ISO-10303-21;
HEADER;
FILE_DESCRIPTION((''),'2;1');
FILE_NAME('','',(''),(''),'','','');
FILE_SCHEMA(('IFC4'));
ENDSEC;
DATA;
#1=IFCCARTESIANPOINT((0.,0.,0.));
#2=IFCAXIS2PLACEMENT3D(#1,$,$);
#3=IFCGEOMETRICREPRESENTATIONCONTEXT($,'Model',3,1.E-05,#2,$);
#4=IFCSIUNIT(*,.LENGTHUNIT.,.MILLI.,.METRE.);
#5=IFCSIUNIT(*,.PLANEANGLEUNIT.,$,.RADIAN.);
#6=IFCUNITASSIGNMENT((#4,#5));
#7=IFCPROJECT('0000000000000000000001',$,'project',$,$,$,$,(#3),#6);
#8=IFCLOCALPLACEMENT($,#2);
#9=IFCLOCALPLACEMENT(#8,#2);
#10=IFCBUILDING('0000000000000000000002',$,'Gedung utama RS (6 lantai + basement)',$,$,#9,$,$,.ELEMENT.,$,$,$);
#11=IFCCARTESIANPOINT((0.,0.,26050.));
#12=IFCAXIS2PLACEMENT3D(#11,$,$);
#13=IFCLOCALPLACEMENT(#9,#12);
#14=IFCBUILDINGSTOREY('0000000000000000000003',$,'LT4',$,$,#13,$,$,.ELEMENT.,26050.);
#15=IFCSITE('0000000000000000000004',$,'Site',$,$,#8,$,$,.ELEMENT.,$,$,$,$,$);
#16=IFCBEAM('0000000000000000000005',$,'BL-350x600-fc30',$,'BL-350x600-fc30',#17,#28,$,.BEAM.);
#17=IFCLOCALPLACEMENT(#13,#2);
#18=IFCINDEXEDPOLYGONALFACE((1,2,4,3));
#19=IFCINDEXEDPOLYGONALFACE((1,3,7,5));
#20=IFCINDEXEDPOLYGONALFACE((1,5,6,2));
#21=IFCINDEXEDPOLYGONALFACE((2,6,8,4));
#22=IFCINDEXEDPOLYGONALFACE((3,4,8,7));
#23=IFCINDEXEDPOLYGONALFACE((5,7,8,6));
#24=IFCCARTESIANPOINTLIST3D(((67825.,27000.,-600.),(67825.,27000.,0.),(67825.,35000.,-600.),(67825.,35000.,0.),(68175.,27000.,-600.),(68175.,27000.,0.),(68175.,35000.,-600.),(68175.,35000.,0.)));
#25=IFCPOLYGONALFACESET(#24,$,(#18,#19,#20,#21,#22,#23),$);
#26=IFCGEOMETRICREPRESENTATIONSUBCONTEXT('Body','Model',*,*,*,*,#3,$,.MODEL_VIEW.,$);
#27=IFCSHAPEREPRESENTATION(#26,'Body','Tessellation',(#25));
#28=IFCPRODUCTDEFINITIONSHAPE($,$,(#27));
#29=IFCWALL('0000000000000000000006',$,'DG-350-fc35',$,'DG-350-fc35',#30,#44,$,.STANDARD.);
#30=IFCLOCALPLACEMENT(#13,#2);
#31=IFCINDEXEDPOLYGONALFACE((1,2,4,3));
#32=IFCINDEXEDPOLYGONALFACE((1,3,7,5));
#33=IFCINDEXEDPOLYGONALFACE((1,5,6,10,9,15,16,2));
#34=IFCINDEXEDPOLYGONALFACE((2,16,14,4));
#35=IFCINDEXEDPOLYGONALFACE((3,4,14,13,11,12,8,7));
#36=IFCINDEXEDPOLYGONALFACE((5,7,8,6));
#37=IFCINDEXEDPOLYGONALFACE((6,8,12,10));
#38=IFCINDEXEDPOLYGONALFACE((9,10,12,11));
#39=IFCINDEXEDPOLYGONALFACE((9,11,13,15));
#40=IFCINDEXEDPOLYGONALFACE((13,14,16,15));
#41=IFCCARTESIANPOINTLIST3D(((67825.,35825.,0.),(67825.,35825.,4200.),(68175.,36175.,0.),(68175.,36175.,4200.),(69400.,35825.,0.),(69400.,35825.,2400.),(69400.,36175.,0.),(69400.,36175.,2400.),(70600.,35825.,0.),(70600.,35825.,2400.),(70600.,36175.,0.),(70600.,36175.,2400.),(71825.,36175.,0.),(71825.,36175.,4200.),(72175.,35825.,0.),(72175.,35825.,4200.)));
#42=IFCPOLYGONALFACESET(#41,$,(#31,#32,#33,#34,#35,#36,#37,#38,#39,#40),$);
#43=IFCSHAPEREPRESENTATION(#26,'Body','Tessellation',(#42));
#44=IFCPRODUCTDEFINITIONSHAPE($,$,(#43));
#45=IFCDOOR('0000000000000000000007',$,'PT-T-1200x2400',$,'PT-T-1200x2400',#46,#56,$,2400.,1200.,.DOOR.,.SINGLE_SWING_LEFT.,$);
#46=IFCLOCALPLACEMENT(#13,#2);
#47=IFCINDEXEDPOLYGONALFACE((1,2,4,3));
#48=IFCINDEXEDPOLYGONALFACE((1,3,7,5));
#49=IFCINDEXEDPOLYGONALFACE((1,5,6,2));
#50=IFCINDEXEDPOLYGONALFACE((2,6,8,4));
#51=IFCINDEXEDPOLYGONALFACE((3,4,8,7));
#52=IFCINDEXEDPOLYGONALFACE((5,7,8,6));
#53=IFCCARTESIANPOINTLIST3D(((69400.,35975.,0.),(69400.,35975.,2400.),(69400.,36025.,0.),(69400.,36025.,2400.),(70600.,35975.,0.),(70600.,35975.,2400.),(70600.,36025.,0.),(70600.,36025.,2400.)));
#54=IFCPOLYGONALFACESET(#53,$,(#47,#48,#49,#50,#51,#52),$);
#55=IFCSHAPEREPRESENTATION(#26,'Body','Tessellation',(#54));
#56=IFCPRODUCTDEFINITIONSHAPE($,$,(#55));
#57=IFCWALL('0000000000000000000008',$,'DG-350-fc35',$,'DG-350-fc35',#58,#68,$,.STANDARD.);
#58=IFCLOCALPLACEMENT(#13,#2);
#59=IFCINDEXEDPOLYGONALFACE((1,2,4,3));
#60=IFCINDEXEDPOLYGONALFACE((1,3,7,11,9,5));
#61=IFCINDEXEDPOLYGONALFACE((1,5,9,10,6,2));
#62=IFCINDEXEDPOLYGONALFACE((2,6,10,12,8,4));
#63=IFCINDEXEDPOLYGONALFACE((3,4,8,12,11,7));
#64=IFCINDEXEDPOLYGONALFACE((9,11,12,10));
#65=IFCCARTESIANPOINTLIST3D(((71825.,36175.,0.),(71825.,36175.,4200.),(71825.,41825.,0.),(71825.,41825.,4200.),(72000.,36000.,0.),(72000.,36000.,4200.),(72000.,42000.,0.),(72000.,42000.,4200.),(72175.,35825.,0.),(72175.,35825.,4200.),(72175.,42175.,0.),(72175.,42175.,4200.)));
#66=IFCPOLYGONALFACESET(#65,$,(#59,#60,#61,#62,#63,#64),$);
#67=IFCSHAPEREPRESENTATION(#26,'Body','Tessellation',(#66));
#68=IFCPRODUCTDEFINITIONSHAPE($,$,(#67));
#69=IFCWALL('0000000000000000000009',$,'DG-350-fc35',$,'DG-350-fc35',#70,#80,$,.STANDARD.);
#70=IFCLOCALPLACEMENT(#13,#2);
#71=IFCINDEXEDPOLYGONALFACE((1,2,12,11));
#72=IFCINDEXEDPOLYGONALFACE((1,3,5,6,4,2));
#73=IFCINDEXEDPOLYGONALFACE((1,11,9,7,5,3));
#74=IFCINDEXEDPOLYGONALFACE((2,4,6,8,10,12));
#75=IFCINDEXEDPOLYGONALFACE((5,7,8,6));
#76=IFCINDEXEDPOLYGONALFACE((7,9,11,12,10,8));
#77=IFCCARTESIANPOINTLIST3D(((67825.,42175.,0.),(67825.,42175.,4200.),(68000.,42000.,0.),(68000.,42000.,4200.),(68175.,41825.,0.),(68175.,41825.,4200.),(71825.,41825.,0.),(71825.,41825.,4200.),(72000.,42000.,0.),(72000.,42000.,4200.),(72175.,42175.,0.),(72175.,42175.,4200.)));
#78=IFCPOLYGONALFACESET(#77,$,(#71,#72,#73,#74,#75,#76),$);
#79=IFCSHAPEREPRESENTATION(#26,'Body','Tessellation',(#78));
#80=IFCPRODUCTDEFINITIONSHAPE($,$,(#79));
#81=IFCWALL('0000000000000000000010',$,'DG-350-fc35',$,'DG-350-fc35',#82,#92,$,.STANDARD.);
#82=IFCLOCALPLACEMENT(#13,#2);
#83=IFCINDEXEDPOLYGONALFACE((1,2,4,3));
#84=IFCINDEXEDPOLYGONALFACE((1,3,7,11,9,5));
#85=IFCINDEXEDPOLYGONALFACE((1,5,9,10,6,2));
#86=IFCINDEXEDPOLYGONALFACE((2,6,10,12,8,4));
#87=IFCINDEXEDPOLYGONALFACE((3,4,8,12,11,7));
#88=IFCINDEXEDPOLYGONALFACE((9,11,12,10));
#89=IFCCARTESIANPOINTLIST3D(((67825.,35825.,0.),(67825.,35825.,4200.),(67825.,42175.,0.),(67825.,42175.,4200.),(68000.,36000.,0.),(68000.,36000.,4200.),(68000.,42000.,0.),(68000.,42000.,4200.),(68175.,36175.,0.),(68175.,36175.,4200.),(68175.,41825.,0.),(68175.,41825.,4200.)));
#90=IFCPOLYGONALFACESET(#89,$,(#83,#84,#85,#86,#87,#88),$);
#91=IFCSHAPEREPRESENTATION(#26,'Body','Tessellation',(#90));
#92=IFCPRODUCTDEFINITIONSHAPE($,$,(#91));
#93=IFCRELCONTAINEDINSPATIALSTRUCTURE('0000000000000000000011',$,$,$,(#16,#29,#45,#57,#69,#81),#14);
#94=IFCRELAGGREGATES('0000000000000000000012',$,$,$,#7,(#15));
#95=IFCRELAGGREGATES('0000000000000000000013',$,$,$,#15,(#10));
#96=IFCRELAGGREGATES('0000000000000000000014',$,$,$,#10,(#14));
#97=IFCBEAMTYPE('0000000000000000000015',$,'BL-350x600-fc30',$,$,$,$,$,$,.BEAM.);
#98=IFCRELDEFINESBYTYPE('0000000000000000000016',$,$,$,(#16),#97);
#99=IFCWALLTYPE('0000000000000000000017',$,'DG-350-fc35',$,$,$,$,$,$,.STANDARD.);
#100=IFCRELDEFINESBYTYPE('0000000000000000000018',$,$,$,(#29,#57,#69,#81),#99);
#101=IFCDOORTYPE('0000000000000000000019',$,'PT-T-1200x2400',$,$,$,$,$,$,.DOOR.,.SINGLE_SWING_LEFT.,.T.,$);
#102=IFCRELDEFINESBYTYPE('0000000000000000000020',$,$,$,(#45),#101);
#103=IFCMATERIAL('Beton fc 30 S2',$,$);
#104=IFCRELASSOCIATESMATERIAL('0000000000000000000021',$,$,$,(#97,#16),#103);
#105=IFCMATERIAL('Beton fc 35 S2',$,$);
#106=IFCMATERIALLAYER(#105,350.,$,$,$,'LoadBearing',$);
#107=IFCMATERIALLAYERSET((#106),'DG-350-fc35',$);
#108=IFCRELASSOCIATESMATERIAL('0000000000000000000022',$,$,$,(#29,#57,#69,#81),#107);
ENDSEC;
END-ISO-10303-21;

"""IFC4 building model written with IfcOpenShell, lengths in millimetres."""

from ifc_helpers import new_model, si_unit, frame, frame_2d, origin, origin_2d, place, context, subcontext, project, spatial, polyline, rectangle, outline, extrude, material, layer, layer_set, layer_usage, material_profile, profile_set, profile_usage, type_object, element, fill, save


model = new_model("IFC4")

# Units and contexts
model_context = context("Model", 3, precision=1e-05, world=origin())
body_context = subcontext(model_context, "Body", "Model", "MODEL_VIEW")
ifc_project = project(units=[si_unit("LENGTHUNIT", "METRE", prefix="MILLI"), si_unit("PLANEANGLEUNIT", "RADIAN")], contexts=[model_context])

# Site, building, storey
site_placement = place(None, origin())
site = spatial("IfcSite", under=ifc_project, at=site_placement, Name="Site", CompositionType="ELEMENT")
building_placement = place(site_placement, origin())
building = spatial("IfcBuilding", under=site, at=building_placement, Name="Gedung utama RS (6 lantai + basement)", CompositionType="ELEMENT")
storey_placement = place(building_placement, frame((0.0, 0.0, 26050.0)))
storey = spatial("IfcBuildingStorey", under=building, at=storey_placement, Name="LT4", CompositionType="ELEMENT", Elevation=26050.0)

# Beam
ifc_material_1 = material(Name="Beton fc 30 S2")
ifc_material_profile_1 = material_profile(ifc_material_1, rectangle(XDim=350.0, YDim=600.0, at=origin_2d()), Name="BL-350x600-fc30")
ifc_profile_set_1 = profile_set([ifc_material_profile_1], Name="BL-350x600-fc30")
ifc_profile_usage_1 = profile_usage(ifc_profile_set_1, cardinal=8)
beam_type = type_object("IfcBeamType", Name="BL-350x600-fc30", PredefinedType="BEAM", material=ifc_profile_set_1)
beam_1_placement = place(storey_placement, frame((68000.0, 27000.0, -300.0)))
element("IfcBeam", 1, at=beam_1_placement, inside=storey, type_object=beam_type, material=ifc_profile_usage_1, Name="BL-350x600-fc30", ObjectType="BL-350x600-fc30", PredefinedType="BEAM", context=body_context, shape_type="SweptSolid", body=[
    extrude(rectangle(XDim=350.0, YDim=600.0, at=origin_2d()), frame((0.0, 0.0, 0.0), z_axis=(0.0, 1.0, 0.0), x_axis=(-1.0, 0.0, 0.0)), (0.0, 0.0, 1.0), 8000.0),
])

# Wall, opening, door
ifc_material_2 = material(Name="Beton fc 35 S2")
ifc_layer = layer(ifc_material_2, 350.0, Category="LoadBearing")
ifc_layer_set = layer_set([ifc_layer], Name="DG-350-fc35")
ifc_layer_usage = layer_usage(ifc_layer_set, "AXIS2", "NEGATIVE", 175.0)
wall_type = type_object("IfcWallType", Name="DG-350-fc35", PredefinedType="STANDARD")
wall_1_placement = place(storey_placement, frame((68000.0, 36000.0, 0.0), z_axis=(0.0, 0.0, 1.0), x_axis=(1.0, 0.0, 0.0)))
wall_1 = element("IfcWall", 2, at=wall_1_placement, inside=storey, type_object=wall_type, material=ifc_layer_usage, Name="DG-350-fc35", ObjectType="DG-350-fc35", PredefinedType="STANDARD", context=body_context, shape_type="SweptSolid", body=[
    extrude(outline(polyline([(-175.0, -175.0), (0.0, 0.0), (175.0, 175.0), (3825.0, 175.0), (4000.0, 0.0), (4175.0, -175.0), (-175.0, -175.0)])), origin(), (0.0, 0.0, 1.0), 4200.0),
])
opening_placement = place(wall_1_placement, frame((1400.0, 0.0, 0.0), z_axis=(0.0, 0.0, 1.0), x_axis=(1.0, 0.0, 0.0)))
opening = element("IfcOpeningElement", 3, at=opening_placement, cuts=wall_1, PredefinedType="OPENING", context=body_context, shape_type="SweptSolid", body=[
    extrude(rectangle(XDim=1200.0, YDim=370.0, at=frame_2d((600.0, 0.0))), origin(), (0.0, 0.0, 1.0), 2400.0),
])
door_type = type_object("IfcDoorType", Name="PT-T-1200x2400", OperationType="SINGLE_SWING_LEFT", ParameterTakesPrecedence=True, PredefinedType="DOOR")
door_placement = place(opening_placement, origin())
door = element("IfcDoor", 4, at=door_placement, inside=storey, type_object=door_type, Name="PT-T-1200x2400", ObjectType="PT-T-1200x2400", OperationType="SINGLE_SWING_LEFT", OverallHeight=2400.0, OverallWidth=1200.0, PredefinedType="DOOR", context=body_context, shape_type="SweptSolid", body=[
    extrude(rectangle(XDim=1200.0, YDim=50.0, at=frame_2d((600.0, 0.0))), origin(), (0.0, 0.0, 1.0), 2400.0),
])
fill(opening, door)

# Walls
wall_2_placement = place(storey_placement, frame((72000.0, 36000.0, 0.0), z_axis=(0.0, 0.0, 1.0), x_axis=(0.0, 1.0, 0.0)))
element("IfcWall", 5, at=wall_2_placement, inside=storey, type_object=wall_type, material=ifc_layer_usage, Name="DG-350-fc35", ObjectType="DG-350-fc35", PredefinedType="STANDARD", context=body_context, shape_type="SweptSolid", body=[
    extrude(outline(polyline([(-175.0, -175.0), (0.0, 0.0), (175.0, 175.0), (5825.0, 175.0), (6000.0, 0.0), (6175.0, -175.0), (-175.0, -175.0)])), origin(), (0.0, 0.0, 1.0), 4200.0),
])
wall_3_placement = place(storey_placement, frame((72000.0, 42000.0, 0.0), z_axis=(0.0, 0.0, 1.0), x_axis=(-1.0, 0.0, 0.0)))
element("IfcWall", 6, at=wall_3_placement, inside=storey, type_object=wall_type, material=ifc_layer_usage, Name="DG-350-fc35", ObjectType="DG-350-fc35", PredefinedType="STANDARD", context=body_context, shape_type="SweptSolid", body=[
    extrude(outline(polyline([(-175.0, -175.0), (0.0, 0.0), (175.0, 175.0), (3825.0, 175.0), (4000.0, 0.0), (4175.0, -175.0), (-175.0, -175.0)])), origin(), (0.0, 0.0, 1.0), 4200.0),
])
wall_4_placement = place(storey_placement, frame((68000.0, 42000.0, 0.0), z_axis=(0.0, 0.0, 1.0), x_axis=(0.0, -1.0, 0.0)))
element("IfcWall", 7, at=wall_4_placement, inside=storey, type_object=wall_type, material=ifc_layer_usage, Name="DG-350-fc35", ObjectType="DG-350-fc35", PredefinedType="STANDARD", context=body_context, shape_type="SweptSolid", body=[
    extrude(outline(polyline([(-175.0, -175.0), (0.0, 0.0), (175.0, 175.0), (5825.0, 175.0), (6000.0, 0.0), (6175.0, -175.0), (-175.0, -175.0)])), origin(), (0.0, 0.0, 1.0), 4200.0),
])

save(model, "model.ifc")
